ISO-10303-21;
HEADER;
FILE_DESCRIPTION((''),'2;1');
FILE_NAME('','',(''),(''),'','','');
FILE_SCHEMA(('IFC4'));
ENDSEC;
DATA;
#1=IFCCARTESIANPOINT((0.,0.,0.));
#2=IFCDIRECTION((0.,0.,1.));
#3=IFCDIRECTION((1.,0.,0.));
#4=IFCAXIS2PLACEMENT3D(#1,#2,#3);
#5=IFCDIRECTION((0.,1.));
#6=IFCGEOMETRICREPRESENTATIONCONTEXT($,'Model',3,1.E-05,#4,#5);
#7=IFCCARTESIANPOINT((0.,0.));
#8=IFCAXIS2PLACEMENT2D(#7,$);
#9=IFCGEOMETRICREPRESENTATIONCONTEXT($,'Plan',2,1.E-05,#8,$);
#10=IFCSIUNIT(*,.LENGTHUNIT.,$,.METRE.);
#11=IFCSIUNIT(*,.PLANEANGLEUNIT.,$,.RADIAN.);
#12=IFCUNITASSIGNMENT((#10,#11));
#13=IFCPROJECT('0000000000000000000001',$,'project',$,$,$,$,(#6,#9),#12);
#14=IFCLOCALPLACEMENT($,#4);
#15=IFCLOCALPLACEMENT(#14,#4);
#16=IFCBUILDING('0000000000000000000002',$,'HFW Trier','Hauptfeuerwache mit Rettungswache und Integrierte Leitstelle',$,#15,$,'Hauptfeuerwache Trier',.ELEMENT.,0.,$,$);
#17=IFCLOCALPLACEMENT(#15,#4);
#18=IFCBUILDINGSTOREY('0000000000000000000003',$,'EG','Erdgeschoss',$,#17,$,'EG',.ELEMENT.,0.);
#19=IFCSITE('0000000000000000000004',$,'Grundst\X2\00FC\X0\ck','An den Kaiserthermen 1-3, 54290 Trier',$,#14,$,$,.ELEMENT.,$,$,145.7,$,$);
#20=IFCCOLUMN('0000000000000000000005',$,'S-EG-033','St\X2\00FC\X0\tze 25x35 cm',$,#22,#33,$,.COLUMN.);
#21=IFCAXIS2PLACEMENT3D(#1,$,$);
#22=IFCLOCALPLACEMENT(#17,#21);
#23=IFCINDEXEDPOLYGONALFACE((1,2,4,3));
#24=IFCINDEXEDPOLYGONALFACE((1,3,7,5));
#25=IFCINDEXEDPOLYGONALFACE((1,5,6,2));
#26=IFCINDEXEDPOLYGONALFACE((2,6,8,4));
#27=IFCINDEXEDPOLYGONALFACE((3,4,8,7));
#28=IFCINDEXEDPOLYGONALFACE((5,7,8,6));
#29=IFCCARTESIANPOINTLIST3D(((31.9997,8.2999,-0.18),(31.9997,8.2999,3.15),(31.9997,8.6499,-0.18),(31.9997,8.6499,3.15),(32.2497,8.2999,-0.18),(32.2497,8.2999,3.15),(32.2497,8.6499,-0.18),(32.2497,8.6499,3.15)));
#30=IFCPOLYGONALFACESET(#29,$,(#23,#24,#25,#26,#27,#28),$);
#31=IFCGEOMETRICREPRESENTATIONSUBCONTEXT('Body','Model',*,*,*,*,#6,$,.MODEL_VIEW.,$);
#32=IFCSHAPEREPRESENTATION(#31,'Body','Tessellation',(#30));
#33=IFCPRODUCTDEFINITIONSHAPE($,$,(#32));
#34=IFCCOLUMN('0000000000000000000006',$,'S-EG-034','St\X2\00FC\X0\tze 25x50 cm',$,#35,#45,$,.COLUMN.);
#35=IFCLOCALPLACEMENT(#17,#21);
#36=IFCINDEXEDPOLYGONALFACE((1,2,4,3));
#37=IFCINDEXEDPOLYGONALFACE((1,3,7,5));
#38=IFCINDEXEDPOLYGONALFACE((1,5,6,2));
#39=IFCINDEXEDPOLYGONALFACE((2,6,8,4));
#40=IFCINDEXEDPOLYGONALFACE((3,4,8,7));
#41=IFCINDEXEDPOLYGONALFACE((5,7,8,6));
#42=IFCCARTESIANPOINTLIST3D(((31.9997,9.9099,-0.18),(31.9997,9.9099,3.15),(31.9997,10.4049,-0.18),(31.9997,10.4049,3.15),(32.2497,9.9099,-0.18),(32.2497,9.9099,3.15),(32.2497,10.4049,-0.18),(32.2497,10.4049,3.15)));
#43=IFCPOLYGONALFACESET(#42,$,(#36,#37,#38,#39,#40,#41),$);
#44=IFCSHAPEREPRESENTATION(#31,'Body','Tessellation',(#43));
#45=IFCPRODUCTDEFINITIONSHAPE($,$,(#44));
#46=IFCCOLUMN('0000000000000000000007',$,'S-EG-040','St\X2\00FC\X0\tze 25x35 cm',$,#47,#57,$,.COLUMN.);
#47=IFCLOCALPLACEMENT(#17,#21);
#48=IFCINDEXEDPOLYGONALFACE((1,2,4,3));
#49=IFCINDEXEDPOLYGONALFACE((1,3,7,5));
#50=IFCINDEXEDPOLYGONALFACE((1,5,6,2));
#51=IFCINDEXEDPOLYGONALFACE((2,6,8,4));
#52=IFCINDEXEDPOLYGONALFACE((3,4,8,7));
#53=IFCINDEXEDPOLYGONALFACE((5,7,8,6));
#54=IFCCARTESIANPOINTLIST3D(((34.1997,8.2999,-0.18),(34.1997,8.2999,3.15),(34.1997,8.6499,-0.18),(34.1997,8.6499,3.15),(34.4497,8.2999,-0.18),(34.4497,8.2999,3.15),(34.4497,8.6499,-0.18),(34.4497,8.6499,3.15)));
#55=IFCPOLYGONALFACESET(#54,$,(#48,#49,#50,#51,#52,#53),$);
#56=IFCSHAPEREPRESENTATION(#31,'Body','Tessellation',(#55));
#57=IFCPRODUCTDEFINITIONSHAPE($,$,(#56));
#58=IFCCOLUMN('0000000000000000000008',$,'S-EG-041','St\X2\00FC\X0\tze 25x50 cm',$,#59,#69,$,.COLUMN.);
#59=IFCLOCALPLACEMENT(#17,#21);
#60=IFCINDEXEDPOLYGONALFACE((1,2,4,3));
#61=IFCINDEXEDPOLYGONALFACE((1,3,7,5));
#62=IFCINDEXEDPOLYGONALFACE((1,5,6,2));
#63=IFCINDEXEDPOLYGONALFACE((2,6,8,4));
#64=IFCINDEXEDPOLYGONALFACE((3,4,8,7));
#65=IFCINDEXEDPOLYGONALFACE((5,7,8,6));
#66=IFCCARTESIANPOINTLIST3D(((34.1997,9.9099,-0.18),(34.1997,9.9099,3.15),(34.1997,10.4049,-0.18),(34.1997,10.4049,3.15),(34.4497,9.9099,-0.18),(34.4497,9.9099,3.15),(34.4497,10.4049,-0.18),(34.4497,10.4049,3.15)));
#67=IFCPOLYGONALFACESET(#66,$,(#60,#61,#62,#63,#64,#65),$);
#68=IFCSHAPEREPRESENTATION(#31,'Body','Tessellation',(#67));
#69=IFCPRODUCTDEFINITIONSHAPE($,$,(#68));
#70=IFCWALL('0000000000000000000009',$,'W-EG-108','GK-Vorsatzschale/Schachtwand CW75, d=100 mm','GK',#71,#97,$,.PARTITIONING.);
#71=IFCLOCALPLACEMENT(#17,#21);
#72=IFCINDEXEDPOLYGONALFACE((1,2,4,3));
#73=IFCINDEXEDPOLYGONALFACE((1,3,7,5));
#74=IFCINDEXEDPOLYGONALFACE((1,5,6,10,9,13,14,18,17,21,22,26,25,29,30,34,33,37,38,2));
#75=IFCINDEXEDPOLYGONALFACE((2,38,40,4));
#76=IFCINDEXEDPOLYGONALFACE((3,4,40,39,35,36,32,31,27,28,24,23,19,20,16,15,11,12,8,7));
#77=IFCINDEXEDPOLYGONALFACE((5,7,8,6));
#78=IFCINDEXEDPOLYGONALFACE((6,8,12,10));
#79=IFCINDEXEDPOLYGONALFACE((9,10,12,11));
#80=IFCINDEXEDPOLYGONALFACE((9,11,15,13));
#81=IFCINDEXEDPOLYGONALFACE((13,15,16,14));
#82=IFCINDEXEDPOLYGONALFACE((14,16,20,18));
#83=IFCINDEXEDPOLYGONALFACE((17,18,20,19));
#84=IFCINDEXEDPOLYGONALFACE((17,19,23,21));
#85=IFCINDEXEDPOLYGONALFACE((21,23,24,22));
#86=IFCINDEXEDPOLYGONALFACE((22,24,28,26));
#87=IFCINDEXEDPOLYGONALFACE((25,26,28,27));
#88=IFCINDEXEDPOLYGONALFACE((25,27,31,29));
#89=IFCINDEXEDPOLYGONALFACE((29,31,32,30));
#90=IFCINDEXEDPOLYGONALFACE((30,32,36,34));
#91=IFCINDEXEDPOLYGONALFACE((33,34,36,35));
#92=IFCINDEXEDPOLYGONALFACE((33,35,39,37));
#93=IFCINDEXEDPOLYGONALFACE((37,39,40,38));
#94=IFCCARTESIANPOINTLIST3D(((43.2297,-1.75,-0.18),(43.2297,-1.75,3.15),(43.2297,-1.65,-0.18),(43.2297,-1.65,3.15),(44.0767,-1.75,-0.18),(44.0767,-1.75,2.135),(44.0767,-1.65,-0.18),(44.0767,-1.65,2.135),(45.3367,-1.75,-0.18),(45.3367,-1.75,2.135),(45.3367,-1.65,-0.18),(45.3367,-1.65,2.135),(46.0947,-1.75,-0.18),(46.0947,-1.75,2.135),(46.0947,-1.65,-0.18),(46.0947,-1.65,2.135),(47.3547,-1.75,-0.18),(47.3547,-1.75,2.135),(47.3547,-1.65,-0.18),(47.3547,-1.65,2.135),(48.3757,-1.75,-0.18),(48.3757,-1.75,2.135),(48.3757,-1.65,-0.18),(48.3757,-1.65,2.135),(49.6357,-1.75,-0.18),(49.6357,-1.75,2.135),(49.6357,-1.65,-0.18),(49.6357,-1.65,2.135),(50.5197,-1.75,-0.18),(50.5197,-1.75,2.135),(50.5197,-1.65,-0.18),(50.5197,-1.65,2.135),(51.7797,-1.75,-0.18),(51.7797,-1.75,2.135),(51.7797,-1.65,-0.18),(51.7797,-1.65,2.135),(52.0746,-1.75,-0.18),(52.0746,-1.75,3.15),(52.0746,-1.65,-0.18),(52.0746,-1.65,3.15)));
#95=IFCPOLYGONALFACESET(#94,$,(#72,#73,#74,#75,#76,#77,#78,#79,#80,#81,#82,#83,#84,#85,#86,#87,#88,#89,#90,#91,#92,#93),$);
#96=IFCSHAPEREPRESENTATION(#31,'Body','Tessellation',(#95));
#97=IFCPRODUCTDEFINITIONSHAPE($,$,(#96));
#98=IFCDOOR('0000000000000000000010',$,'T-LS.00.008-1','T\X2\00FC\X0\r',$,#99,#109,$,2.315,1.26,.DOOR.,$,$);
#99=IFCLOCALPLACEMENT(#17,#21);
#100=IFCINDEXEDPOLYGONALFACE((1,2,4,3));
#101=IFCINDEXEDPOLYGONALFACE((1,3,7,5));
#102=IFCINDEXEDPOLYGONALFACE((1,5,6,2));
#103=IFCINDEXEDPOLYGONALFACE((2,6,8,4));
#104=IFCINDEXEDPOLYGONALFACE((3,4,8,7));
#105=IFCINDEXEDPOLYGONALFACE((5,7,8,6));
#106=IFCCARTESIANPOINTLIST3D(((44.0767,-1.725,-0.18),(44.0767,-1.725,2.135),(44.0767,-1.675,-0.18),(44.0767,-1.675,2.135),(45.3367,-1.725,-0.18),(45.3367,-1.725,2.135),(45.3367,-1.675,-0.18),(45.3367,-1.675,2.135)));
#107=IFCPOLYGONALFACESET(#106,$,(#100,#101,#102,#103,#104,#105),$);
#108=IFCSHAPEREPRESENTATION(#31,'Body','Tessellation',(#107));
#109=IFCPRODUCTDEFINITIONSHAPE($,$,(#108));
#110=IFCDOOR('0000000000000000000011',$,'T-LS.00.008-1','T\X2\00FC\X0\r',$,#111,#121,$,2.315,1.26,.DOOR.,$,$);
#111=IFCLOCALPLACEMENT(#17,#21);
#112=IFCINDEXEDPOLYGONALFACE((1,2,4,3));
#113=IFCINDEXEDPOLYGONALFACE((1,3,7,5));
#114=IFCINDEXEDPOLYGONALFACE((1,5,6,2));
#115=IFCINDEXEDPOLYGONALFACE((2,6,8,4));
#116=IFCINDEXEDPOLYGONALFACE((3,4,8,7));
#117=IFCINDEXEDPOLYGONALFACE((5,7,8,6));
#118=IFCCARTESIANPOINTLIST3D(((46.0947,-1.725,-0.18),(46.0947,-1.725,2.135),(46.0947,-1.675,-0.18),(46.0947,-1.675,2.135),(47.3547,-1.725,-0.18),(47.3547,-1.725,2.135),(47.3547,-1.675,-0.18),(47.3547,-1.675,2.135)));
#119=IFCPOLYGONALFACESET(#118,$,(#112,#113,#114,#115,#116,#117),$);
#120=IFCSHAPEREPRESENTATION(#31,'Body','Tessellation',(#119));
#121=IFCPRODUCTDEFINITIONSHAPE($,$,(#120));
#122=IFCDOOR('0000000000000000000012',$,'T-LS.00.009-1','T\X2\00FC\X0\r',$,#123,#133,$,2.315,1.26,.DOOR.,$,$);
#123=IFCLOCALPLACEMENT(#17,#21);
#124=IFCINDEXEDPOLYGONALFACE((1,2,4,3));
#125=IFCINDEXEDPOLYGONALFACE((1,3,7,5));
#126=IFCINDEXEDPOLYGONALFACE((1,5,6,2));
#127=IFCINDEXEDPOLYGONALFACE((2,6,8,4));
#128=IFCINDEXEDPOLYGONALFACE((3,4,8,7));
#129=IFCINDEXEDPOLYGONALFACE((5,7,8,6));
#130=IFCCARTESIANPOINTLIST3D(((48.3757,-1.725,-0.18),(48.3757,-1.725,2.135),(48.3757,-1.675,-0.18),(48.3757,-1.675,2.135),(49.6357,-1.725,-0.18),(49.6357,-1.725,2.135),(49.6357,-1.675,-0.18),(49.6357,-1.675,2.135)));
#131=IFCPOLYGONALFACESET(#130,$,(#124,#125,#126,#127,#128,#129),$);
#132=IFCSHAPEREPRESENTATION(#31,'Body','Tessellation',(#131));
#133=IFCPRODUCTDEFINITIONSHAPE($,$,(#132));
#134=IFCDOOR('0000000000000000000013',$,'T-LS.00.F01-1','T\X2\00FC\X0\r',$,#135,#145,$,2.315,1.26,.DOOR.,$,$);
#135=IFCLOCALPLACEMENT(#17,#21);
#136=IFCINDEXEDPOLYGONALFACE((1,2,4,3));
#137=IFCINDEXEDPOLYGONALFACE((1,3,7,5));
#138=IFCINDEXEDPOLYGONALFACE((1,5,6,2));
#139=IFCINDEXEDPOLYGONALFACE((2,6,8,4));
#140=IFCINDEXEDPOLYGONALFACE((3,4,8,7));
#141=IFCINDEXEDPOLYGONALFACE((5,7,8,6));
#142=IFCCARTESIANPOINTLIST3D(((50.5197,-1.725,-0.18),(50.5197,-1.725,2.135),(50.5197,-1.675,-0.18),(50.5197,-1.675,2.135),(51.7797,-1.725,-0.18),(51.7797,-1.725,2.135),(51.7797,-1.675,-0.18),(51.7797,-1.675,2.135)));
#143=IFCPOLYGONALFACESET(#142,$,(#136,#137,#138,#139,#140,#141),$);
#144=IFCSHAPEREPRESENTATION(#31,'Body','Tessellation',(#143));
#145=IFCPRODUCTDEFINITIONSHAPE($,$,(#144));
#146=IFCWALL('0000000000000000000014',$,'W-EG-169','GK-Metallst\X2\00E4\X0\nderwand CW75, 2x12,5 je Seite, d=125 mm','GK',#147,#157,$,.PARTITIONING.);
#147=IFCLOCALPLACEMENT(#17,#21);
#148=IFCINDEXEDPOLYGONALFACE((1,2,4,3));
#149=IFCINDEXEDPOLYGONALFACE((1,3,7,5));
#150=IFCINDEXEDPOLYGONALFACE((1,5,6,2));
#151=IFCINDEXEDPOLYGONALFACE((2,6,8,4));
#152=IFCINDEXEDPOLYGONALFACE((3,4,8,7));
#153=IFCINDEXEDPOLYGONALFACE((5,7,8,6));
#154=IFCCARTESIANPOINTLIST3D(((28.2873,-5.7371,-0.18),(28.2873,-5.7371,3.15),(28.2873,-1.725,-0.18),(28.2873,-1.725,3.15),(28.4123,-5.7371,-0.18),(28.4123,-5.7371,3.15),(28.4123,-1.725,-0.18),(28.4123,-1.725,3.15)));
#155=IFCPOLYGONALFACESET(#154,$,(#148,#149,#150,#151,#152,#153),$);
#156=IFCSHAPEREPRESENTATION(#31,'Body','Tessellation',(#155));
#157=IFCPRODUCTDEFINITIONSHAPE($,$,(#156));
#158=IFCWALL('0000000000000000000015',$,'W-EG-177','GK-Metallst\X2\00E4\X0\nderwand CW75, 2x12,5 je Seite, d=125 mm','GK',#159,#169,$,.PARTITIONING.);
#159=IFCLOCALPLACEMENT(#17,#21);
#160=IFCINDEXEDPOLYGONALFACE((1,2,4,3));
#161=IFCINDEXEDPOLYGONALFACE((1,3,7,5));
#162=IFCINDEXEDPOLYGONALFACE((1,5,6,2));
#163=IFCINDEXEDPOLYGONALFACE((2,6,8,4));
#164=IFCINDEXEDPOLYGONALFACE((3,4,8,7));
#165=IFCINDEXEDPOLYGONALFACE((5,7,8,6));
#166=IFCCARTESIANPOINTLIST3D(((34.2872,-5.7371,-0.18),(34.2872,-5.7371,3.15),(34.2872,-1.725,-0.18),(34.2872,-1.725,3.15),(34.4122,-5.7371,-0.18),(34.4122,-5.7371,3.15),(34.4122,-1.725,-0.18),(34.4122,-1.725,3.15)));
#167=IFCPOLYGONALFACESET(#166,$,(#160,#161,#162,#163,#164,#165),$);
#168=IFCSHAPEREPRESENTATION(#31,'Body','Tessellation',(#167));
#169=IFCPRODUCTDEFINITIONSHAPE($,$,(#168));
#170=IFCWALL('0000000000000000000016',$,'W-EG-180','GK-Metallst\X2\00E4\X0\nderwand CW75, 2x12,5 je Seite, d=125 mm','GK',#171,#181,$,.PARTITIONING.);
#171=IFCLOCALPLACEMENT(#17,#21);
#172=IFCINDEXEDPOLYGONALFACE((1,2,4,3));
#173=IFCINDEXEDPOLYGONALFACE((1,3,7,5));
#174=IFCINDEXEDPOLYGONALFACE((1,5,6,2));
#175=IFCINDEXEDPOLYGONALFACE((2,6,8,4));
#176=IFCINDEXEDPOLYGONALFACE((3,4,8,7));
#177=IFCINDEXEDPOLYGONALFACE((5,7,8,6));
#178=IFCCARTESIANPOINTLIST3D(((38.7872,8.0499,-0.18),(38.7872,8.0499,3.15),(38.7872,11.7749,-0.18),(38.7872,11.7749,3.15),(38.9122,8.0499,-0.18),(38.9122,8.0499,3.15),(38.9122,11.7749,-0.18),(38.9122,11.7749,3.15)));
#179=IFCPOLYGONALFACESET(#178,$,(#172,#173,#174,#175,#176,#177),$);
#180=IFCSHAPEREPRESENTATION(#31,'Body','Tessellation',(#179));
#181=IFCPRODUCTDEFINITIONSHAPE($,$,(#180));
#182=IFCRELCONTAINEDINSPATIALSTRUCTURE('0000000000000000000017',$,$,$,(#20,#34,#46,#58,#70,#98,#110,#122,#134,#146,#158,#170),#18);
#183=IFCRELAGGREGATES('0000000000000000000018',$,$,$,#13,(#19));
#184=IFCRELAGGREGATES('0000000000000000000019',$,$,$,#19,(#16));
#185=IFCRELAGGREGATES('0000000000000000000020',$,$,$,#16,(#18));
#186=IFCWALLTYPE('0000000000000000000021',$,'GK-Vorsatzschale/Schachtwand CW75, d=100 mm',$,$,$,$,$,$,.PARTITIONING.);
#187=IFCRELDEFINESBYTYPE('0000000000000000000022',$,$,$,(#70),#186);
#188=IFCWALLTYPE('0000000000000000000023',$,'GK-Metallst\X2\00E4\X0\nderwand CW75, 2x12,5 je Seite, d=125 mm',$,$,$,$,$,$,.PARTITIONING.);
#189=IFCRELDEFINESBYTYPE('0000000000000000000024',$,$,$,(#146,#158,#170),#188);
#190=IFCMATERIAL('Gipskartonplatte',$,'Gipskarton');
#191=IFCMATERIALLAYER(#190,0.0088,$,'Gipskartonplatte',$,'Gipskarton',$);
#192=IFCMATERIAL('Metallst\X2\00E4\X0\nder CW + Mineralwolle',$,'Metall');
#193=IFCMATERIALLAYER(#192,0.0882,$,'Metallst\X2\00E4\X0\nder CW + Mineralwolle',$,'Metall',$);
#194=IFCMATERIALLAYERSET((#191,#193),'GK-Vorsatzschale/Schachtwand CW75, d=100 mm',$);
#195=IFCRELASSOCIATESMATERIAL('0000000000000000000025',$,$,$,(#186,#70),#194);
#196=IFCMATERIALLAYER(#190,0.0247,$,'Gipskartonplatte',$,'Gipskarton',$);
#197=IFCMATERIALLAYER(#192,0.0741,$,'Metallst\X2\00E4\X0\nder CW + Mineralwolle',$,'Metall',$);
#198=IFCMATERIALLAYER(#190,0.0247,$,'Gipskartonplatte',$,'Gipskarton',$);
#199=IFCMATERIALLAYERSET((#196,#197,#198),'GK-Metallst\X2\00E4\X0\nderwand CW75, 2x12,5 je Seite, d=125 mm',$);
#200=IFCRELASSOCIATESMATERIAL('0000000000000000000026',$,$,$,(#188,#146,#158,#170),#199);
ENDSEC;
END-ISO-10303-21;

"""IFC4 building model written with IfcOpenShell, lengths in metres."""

from ifc_helpers import new_model, si_unit, direction, frame, frame_2d, origin_with_axes, origin_2d, place, context, subcontext, project, spatial, rectangle, extrude, material, layer, layer_set, layer_usage, type_object, element, fill, save


model = new_model("IFC4")

# Units and contexts
model_context = context("Model", 3, precision=1e-05, world=origin_with_axes(), true_north=direction((0.0, 1.0)))
plan_context = context("Plan", 2, precision=1e-05, world=origin_2d())
body_context = subcontext(model_context, "Body", "Model", "MODEL_VIEW")
ifc_project = project(units=[si_unit("LENGTHUNIT", "METRE"), si_unit("PLANEANGLEUNIT", "RADIAN")], contexts=[model_context, plan_context])

# Site, building, storey
site_placement = place(None, origin_with_axes())
site = spatial("IfcSite", under=ifc_project, at=site_placement, Name="Grundstück", Description="An den Kaiserthermen 1-3, 54290 Trier", CompositionType="ELEMENT", RefElevation=145.7)
building_placement = place(site_placement, origin_with_axes())
building = spatial("IfcBuilding", under=site, at=building_placement, Name="HFW Trier", Description="Hauptfeuerwache mit Rettungswache und Integrierte Leitstelle", LongName="Hauptfeuerwache Trier", CompositionType="ELEMENT", ElevationOfRefHeight=0.0)
storey_placement = place(building_placement, origin_with_axes())
storey = spatial("IfcBuildingStorey", under=building, at=storey_placement, Name="EG", Description="Erdgeschoss", LongName="EG", CompositionType="ELEMENT", Elevation=0.0)

# Columns
column_1_placement = place(storey_placement, frame((31.9997, 8.4749, -0.18), z_axis=(0.0, 0.0, 1.0), x_axis=(1.0, 0.0, 0.0)))
element("IfcColumn", 1, at=column_1_placement, inside=storey, Name="S-EG-033", Description="Stütze 25x35 cm", PredefinedType="COLUMN", context=body_context, shape_type="SweptSolid", body=[
    extrude(rectangle(XDim=0.25, YDim=0.35, at=frame_2d((0.125, 0.0))), origin_with_axes(), (0.0, 0.0, 1.0), 3.33),
])
column_2_placement = place(storey_placement, frame((31.9997, 10.1574, -0.18), z_axis=(0.0, 0.0, 1.0), x_axis=(1.0, 0.0, 0.0)))
element("IfcColumn", 2, at=column_2_placement, inside=storey, Name="S-EG-034", Description="Stütze 25x50 cm", PredefinedType="COLUMN", context=body_context, shape_type="SweptSolid", body=[
    extrude(rectangle(XDim=0.25, YDim=0.495, at=frame_2d((0.125, 0.0))), origin_with_axes(), (0.0, 0.0, 1.0), 3.33),
])
column_3_placement = place(storey_placement, frame((34.1997, 8.4749, -0.18), z_axis=(0.0, 0.0, 1.0), x_axis=(1.0, 0.0, 0.0)))
element("IfcColumn", 3, at=column_3_placement, inside=storey, Name="S-EG-040", Description="Stütze 25x35 cm", PredefinedType="COLUMN", context=body_context, shape_type="SweptSolid", body=[
    extrude(rectangle(XDim=0.25, YDim=0.35, at=frame_2d((0.125, 0.0))), origin_with_axes(), (0.0, 0.0, 1.0), 3.33),
])
column_4_placement = place(storey_placement, frame((34.1997, 10.1574, -0.18), z_axis=(0.0, 0.0, 1.0), x_axis=(1.0, 0.0, 0.0)))
element("IfcColumn", 4, at=column_4_placement, inside=storey, Name="S-EG-041", Description="Stütze 25x50 cm", PredefinedType="COLUMN", context=body_context, shape_type="SweptSolid", body=[
    extrude(rectangle(XDim=0.25, YDim=0.495, at=frame_2d((0.125, 0.0))), origin_with_axes(), (0.0, 0.0, 1.0), 3.33),
])

# Wall, openings, doors
ifc_material_1 = material(Name="Gipskartonplatte", Category="Gipskarton")
ifc_layer_1 = layer(ifc_material_1, 0.0088, Name="Gipskartonplatte", Category="Gipskarton")
ifc_material_2 = material(Name="Metallständer CW + Mineralwolle", Category="Metall")
ifc_layer_2 = layer(ifc_material_2, 0.0882, Name="Metallständer CW + Mineralwolle", Category="Metall")
ifc_layer_set_1 = layer_set([ifc_layer_1, ifc_layer_2], Name="GK-Vorsatzschale/Schachtwand CW75, d=100 mm")
ifc_layer_usage_1 = layer_usage(ifc_layer_set_1, "AXIS2", "POSITIVE", -0.05)
wall_type_1 = type_object("IfcWallType", Name="GK-Vorsatzschale/Schachtwand CW75, d=100 mm", PredefinedType="PARTITIONING", material=ifc_layer_set_1)
wall_1_placement = place(storey_placement, frame((43.2297, -1.7, -0.18), z_axis=(0.0, 0.0, 1.0), x_axis=(1.0, 0.0, 0.0)))
wall_1 = element("IfcWall", 5, at=wall_1_placement, inside=storey, type_object=wall_type_1, material=ifc_layer_usage_1, Name="W-EG-108", Description="GK-Vorsatzschale/Schachtwand CW75, d=100 mm", ObjectType="GK", PredefinedType="PARTITIONING", context=body_context, shape_type="SweptSolid", body=[
    extrude(rectangle(XDim=8.8449, YDim=0.1, at=frame_2d((4.4224, 0.0))), origin_with_axes(), (0.0, 0.0, 1.0), 3.33),
])
opening_1_placement = place(wall_1_placement, frame((0.847, 0.0, 0.0), z_axis=(0.0, 0.0, 1.0), x_axis=(1.0, 0.0, 0.0)))
opening_1 = element("IfcOpeningElement", 6, at=opening_1_placement, cuts=wall_1, PredefinedType="OPENING", context=body_context, shape_type="SweptSolid", body=[
    extrude(rectangle(XDim=1.26, YDim=0.2, at=frame_2d((0.63, 0.0))), origin_with_axes(), (0.0, 0.0, 1.0), 2.315),
])
opening_2_placement = place(wall_1_placement, frame((2.865, 0.0, 0.0), z_axis=(0.0, 0.0, 1.0), x_axis=(1.0, 0.0, 0.0)))
opening_2 = element("IfcOpeningElement", 7, at=opening_2_placement, cuts=wall_1, PredefinedType="OPENING", context=body_context, shape_type="SweptSolid", body=[
    extrude(rectangle(XDim=1.26, YDim=0.2, at=frame_2d((0.63, 0.0))), origin_with_axes(), (0.0, 0.0, 1.0), 2.315),
])
opening_3_placement = place(wall_1_placement, frame((5.146, 0.0, 0.0), z_axis=(0.0, 0.0, 1.0), x_axis=(1.0, 0.0, 0.0)))
opening_3 = element("IfcOpeningElement", 8, at=opening_3_placement, cuts=wall_1, PredefinedType="OPENING", context=body_context, shape_type="SweptSolid", body=[
    extrude(rectangle(XDim=1.26, YDim=0.2, at=frame_2d((0.63, 0.0))), origin_with_axes(), (0.0, 0.0, 1.0), 2.315),
])
opening_4_placement = place(wall_1_placement, frame((7.29, 0.0, 0.0), z_axis=(0.0, 0.0, 1.0), x_axis=(1.0, 0.0, 0.0)))
opening_4 = element("IfcOpeningElement", 9, at=opening_4_placement, cuts=wall_1, PredefinedType="OPENING", context=body_context, shape_type="SweptSolid", body=[
    extrude(rectangle(XDim=1.26, YDim=0.2, at=frame_2d((0.63, 0.0))), origin_with_axes(), (0.0, 0.0, 1.0), 2.315),
])
door_1_placement = place(wall_1_placement, frame((0.847, 0.0, 0.0), z_axis=(0.0, 0.0, 1.0), x_axis=(1.0, 0.0, 0.0)))
door_1 = element("IfcDoor", 10, at=door_1_placement, inside=storey, Name="T-LS.00.008-1", Description="Tür", OverallHeight=2.315, OverallWidth=1.26, PredefinedType="DOOR", context=body_context, shape_type="SweptSolid", body=[
    extrude(rectangle(XDim=1.26, YDim=0.05, at=frame_2d((0.63, 0.0))), origin_with_axes(), (0.0, 0.0, 1.0), 2.315),
])
fill(opening_1, door_1)
door_2_placement = place(wall_1_placement, frame((2.865, 0.0, 0.0), z_axis=(0.0, 0.0, 1.0), x_axis=(1.0, 0.0, 0.0)))
door_2 = element("IfcDoor", 11, at=door_2_placement, inside=storey, Name="T-LS.00.008-1", Description="Tür", OverallHeight=2.315, OverallWidth=1.26, PredefinedType="DOOR", context=body_context, shape_type="SweptSolid", body=[
    extrude(rectangle(XDim=1.26, YDim=0.05, at=frame_2d((0.63, 0.0))), origin_with_axes(), (0.0, 0.0, 1.0), 2.315),
])
fill(opening_2, door_2)
door_3_placement = place(wall_1_placement, frame((5.146, 0.0, 0.0), z_axis=(0.0, 0.0, 1.0), x_axis=(1.0, 0.0, 0.0)))
door_3 = element("IfcDoor", 12, at=door_3_placement, inside=storey, Name="T-LS.00.009-1", Description="Tür", OverallHeight=2.315, OverallWidth=1.26, PredefinedType="DOOR", context=body_context, shape_type="SweptSolid", body=[
    extrude(rectangle(XDim=1.26, YDim=0.05, at=frame_2d((0.63, 0.0))), origin_with_axes(), (0.0, 0.0, 1.0), 2.315),
])
fill(opening_3, door_3)
door_4_placement = place(wall_1_placement, frame((7.29, 0.0, 0.0), z_axis=(0.0, 0.0, 1.0), x_axis=(1.0, 0.0, 0.0)))
door_4 = element("IfcDoor", 13, at=door_4_placement, inside=storey, Name="T-LS.00.F01-1", Description="Tür", OverallHeight=2.315, OverallWidth=1.26, PredefinedType="DOOR", context=body_context, shape_type="SweptSolid", body=[
    extrude(rectangle(XDim=1.26, YDim=0.05, at=frame_2d((0.63, 0.0))), origin_with_axes(), (0.0, 0.0, 1.0), 2.315),
])
fill(opening_4, door_4)

# Walls
ifc_layer_3 = layer(ifc_material_1, 0.0247, Name="Gipskartonplatte", Category="Gipskarton")
ifc_layer_4 = layer(ifc_material_2, 0.0741, Name="Metallständer CW + Mineralwolle", Category="Metall")
ifc_layer_5 = layer(ifc_material_1, 0.0247, Name="Gipskartonplatte", Category="Gipskarton")
ifc_layer_set_2 = layer_set([ifc_layer_3, ifc_layer_4, ifc_layer_5], Name="GK-Metallständerwand CW75, 2x12,5 je Seite, d=125 mm")
ifc_layer_usage_2 = layer_usage(ifc_layer_set_2, "AXIS2", "POSITIVE", -0.0625)
wall_type_2 = type_object("IfcWallType", Name="GK-Metallständerwand CW75, 2x12,5 je Seite, d=125 mm", PredefinedType="PARTITIONING", material=ifc_layer_set_2)
wall_2_placement = place(storey_placement, frame((28.3498, -1.725, -0.18), z_axis=(0.0, 0.0, 1.0), x_axis=(0.0, -1.0, 0.0)))
element("IfcWall", 14, at=wall_2_placement, inside=storey, type_object=wall_type_2, material=ifc_layer_usage_2, Name="W-EG-169", Description="GK-Metallständerwand CW75, 2x12,5 je Seite, d=125 mm", ObjectType="GK", PredefinedType="PARTITIONING", context=body_context, shape_type="SweptSolid", body=[
    extrude(rectangle(XDim=4.0121, YDim=0.125, at=frame_2d((2.0061, 0.0))), origin_with_axes(), (0.0, 0.0, 1.0), 3.33),
])
ifc_layer_usage_3 = layer_usage(ifc_layer_set_2, "AXIS2", "POSITIVE", -0.0625)
wall_3_placement = place(storey_placement, frame((34.3497, -1.725, -0.18), z_axis=(0.0, 0.0, 1.0), x_axis=(0.0, -1.0, 0.0)))
element("IfcWall", 15, at=wall_3_placement, inside=storey, type_object=wall_type_2, material=ifc_layer_usage_3, Name="W-EG-177", Description="GK-Metallständerwand CW75, 2x12,5 je Seite, d=125 mm", ObjectType="GK", PredefinedType="PARTITIONING", context=body_context, shape_type="SweptSolid", body=[
    extrude(rectangle(XDim=4.0121, YDim=0.125, at=frame_2d((2.0061, 0.0))), origin_with_axes(), (0.0, 0.0, 1.0), 3.33),
])
ifc_layer_usage_4 = layer_usage(ifc_layer_set_2, "AXIS2", "POSITIVE", -0.0625)
wall_4_placement = place(storey_placement, frame((38.8497, 11.7749, -0.18), z_axis=(0.0, 0.0, 1.0), x_axis=(0.0, -1.0, 0.0)))
element("IfcWall", 16, at=wall_4_placement, inside=storey, type_object=wall_type_2, material=ifc_layer_usage_4, Name="W-EG-180", Description="GK-Metallständerwand CW75, 2x12,5 je Seite, d=125 mm", ObjectType="GK", PredefinedType="PARTITIONING", context=body_context, shape_type="SweptSolid", body=[
    extrude(rectangle(XDim=3.725, YDim=0.125, at=frame_2d((1.8625, 0.0))), origin_with_axes(), (0.0, 0.0, 1.0), 3.33),
])

save(model, "model.ifc")
